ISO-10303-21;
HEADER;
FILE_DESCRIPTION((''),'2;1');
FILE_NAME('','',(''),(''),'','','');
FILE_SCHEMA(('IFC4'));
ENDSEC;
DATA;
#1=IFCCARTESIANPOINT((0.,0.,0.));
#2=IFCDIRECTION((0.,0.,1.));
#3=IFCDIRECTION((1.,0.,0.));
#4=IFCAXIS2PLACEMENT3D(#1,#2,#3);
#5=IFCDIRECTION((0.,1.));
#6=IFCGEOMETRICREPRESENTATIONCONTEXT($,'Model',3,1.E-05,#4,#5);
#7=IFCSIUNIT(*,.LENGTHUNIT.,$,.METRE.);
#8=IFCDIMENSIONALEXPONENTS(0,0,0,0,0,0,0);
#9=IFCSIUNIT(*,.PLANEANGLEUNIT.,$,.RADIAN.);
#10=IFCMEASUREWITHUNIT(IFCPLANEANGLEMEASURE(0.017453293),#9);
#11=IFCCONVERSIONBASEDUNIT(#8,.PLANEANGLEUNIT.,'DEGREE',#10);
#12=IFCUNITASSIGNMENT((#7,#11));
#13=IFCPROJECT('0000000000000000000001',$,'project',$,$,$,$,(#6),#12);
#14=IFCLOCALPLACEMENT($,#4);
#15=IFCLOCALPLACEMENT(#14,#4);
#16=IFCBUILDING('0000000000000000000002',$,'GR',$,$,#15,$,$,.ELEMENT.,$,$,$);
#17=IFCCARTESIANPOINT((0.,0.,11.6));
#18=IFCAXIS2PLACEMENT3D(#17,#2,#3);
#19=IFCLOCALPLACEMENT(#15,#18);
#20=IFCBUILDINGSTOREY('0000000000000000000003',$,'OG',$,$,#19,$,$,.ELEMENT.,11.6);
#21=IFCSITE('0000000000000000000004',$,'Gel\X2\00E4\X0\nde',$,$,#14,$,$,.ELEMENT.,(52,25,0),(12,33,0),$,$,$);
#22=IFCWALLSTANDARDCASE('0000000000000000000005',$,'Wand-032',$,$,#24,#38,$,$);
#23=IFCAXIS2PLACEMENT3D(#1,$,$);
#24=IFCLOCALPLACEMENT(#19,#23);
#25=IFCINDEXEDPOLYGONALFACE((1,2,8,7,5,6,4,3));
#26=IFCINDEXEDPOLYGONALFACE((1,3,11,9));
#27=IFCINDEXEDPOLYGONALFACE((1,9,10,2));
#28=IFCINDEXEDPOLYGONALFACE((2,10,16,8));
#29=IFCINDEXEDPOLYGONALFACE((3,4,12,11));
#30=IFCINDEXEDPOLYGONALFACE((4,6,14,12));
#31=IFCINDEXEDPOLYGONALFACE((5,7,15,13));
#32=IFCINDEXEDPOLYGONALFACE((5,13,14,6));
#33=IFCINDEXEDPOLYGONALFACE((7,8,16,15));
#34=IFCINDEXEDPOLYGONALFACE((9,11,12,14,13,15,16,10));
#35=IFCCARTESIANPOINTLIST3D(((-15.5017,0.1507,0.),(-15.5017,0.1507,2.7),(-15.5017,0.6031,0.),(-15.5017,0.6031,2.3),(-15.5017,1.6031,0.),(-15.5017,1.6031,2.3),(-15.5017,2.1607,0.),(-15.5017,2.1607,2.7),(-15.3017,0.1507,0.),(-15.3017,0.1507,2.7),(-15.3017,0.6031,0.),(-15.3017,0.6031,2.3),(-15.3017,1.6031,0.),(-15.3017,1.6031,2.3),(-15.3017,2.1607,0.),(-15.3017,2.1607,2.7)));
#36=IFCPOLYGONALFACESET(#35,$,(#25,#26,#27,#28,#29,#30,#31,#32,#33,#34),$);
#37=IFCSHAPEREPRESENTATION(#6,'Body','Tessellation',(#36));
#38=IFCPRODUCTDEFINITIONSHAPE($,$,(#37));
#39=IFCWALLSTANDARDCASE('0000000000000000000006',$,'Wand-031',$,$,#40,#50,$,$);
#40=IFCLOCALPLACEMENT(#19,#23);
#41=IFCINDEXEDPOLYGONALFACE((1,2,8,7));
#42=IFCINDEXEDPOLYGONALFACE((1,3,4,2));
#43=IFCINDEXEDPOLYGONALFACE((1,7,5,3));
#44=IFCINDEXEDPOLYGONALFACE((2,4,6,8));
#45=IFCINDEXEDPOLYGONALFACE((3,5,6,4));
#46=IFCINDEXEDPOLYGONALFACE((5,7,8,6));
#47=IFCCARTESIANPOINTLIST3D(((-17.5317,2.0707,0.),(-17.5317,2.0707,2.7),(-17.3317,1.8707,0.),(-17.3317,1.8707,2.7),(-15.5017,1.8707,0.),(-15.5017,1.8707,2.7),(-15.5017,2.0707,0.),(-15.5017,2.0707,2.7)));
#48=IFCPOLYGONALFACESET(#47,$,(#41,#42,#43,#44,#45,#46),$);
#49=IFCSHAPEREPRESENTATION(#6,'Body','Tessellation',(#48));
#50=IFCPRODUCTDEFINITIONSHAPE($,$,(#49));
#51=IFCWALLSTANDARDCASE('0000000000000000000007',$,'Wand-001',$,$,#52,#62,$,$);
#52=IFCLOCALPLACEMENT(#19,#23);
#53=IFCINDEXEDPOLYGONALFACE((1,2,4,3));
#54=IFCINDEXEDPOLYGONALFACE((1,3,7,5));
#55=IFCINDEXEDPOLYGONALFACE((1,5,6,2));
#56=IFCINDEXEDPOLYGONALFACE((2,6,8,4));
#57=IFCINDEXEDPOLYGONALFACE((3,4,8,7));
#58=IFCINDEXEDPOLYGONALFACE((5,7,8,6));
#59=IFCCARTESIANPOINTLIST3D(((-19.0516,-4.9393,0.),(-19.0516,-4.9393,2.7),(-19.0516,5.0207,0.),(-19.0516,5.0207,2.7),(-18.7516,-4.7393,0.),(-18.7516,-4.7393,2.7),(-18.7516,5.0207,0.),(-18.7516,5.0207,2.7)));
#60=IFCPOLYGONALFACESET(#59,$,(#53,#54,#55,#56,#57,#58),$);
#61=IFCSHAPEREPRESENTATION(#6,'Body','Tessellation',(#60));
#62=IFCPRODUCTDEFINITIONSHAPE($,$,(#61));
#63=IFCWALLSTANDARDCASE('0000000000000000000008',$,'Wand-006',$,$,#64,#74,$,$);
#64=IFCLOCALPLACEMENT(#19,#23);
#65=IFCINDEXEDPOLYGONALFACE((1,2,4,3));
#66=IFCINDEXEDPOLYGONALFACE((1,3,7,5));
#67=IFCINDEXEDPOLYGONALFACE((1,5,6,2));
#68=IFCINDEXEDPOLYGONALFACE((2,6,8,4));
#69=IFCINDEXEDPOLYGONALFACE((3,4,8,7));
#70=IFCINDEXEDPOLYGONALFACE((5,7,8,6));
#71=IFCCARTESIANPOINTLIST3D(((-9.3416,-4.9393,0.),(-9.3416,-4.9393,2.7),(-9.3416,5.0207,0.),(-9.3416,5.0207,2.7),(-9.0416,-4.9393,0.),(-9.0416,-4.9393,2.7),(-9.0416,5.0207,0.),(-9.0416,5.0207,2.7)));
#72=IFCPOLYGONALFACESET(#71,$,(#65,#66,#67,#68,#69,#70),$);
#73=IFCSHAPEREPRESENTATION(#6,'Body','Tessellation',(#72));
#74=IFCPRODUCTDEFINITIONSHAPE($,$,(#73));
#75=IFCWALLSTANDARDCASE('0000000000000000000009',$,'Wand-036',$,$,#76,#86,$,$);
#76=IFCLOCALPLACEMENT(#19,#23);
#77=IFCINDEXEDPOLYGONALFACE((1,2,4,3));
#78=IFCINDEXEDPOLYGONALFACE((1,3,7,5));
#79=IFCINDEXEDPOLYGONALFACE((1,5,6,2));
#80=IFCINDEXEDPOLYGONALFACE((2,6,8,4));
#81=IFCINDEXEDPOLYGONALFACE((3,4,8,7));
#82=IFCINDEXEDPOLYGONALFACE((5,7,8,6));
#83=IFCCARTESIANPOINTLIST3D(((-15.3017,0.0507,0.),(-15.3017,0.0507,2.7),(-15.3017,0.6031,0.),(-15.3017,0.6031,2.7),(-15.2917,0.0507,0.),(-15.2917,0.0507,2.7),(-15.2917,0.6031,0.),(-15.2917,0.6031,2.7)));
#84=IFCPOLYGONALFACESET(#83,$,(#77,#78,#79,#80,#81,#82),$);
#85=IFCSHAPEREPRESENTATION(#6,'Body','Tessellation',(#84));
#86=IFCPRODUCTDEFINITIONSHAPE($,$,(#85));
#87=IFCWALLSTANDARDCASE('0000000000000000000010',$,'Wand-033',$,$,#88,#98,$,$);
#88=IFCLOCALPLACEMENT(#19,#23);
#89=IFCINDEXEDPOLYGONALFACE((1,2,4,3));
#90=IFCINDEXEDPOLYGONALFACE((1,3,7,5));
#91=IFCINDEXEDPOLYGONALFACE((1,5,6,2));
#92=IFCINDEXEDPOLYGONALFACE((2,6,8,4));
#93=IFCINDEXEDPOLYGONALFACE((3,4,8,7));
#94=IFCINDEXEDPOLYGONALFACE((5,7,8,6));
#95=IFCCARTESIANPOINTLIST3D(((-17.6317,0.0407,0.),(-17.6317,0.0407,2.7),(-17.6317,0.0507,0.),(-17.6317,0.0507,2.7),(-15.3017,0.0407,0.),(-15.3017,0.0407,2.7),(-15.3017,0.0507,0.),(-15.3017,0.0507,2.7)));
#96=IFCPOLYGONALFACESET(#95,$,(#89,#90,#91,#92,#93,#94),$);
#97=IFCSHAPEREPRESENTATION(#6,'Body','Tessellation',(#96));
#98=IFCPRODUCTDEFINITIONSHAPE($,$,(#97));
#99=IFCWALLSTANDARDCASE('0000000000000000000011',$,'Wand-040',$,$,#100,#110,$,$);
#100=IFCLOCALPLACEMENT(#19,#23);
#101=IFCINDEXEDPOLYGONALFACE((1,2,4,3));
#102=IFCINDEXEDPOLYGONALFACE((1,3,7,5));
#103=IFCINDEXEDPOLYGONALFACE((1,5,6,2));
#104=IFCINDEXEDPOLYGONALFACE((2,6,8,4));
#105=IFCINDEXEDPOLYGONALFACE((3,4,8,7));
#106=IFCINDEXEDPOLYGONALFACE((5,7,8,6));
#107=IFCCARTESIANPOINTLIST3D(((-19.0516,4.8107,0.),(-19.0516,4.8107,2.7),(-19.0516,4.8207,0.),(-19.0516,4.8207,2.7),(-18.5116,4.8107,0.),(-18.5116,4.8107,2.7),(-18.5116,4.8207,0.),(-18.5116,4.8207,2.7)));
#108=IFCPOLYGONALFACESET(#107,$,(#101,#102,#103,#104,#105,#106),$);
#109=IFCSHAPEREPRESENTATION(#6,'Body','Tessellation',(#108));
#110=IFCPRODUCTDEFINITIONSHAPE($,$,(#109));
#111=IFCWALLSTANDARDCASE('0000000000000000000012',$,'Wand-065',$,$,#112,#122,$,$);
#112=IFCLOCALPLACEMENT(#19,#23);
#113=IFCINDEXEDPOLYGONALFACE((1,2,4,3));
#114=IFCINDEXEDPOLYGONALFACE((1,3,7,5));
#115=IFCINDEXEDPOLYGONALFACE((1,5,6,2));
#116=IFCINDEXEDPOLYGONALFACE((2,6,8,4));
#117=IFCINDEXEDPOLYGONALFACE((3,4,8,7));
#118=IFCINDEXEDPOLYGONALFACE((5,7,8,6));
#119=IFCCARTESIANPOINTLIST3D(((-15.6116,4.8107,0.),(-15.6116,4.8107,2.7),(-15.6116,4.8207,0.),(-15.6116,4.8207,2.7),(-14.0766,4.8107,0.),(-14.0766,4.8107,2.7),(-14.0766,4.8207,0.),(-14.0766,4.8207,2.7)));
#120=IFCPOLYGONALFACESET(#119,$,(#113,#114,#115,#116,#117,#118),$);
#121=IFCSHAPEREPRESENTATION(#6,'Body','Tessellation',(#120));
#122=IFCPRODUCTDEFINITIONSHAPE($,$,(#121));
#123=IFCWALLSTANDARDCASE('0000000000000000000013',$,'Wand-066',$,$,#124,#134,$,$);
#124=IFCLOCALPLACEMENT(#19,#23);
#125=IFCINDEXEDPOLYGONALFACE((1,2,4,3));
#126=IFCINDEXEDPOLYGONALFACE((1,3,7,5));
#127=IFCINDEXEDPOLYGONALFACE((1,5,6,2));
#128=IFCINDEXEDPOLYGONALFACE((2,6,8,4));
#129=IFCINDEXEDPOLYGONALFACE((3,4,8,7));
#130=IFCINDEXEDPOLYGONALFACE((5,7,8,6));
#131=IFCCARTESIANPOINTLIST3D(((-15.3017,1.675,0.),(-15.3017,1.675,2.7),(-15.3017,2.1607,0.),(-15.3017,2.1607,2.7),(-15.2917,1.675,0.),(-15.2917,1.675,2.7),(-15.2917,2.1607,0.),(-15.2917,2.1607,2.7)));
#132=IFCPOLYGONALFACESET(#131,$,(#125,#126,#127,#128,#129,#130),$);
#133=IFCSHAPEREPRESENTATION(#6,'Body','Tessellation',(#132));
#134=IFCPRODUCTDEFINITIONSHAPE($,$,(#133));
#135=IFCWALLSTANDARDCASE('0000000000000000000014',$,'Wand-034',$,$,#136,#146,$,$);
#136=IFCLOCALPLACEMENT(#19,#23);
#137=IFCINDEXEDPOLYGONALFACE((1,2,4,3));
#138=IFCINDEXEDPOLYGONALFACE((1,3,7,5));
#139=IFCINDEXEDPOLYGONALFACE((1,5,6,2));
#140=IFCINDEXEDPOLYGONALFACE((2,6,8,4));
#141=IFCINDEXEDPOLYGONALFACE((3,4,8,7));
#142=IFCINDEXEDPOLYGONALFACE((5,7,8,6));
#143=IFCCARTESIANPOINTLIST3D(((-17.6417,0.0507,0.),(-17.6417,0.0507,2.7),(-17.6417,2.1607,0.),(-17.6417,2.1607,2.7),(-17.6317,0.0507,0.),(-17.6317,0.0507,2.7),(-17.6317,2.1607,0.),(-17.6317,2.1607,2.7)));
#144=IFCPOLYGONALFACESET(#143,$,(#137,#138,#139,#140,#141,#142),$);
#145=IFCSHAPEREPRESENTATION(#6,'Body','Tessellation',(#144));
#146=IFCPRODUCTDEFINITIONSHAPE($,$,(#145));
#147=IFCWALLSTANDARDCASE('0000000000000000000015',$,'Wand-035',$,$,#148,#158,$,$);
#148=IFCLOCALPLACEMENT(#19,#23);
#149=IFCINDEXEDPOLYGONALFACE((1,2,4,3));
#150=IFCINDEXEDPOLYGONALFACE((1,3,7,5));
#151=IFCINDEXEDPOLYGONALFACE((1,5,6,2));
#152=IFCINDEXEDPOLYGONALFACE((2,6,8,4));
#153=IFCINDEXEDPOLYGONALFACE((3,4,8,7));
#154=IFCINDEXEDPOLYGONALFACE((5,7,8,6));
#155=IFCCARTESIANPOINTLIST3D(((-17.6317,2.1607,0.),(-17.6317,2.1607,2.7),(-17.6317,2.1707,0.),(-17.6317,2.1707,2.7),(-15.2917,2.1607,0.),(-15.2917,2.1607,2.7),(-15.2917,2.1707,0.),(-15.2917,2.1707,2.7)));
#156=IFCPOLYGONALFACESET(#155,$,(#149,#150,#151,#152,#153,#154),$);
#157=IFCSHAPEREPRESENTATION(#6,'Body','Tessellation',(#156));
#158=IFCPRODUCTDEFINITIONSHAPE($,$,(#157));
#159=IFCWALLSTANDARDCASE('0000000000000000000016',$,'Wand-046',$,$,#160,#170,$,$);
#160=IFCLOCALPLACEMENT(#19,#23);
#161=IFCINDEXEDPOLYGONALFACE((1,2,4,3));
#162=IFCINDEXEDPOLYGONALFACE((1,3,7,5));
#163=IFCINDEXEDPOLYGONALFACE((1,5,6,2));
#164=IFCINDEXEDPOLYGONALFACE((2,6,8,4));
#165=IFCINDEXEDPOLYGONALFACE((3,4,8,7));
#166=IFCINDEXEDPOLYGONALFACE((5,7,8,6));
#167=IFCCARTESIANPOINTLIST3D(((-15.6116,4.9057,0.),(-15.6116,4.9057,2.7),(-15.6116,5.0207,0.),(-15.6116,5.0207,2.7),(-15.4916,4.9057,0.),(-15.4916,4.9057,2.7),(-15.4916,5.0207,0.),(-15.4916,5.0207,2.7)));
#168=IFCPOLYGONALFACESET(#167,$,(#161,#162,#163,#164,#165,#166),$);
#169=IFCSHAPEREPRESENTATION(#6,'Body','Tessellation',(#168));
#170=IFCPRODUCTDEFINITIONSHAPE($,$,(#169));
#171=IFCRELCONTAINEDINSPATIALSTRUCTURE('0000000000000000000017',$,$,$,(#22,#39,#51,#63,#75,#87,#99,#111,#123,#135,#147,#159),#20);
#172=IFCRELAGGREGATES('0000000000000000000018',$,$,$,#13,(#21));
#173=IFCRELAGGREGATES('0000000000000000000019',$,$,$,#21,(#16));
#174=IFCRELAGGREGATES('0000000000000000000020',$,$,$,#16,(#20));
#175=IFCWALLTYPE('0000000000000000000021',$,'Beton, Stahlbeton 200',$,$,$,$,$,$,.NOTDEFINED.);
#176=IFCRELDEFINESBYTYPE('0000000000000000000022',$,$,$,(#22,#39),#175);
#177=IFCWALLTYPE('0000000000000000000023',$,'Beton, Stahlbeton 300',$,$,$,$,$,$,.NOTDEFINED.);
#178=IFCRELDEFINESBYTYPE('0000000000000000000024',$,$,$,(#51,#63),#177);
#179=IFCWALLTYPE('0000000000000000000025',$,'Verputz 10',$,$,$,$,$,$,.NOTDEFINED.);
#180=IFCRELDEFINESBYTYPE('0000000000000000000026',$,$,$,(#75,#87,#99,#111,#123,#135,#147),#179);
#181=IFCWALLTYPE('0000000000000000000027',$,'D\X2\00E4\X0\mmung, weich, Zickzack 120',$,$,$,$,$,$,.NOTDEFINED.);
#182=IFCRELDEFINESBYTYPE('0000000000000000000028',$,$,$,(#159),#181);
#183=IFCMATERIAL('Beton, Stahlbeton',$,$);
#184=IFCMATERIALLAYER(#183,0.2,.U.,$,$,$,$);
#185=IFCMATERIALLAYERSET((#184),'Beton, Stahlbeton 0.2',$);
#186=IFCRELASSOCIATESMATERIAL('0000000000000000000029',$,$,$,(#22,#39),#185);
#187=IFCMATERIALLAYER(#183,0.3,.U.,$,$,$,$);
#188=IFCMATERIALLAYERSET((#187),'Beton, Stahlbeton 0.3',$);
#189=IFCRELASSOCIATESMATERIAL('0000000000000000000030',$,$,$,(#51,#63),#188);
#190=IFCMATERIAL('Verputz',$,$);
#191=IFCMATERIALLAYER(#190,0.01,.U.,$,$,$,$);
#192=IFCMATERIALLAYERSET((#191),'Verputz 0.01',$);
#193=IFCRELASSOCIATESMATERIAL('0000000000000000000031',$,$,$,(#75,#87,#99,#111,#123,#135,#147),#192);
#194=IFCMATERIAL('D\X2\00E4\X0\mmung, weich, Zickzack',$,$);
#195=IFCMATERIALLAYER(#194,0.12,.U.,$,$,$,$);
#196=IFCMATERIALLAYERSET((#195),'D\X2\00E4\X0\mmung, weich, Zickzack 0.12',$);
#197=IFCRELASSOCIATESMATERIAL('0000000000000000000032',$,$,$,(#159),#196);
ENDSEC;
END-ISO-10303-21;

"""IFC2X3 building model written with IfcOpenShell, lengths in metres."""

from ifc_helpers import new_model, entity, si_unit, converted_unit, direction, frame, origin_with_axes, origin_2d_with_axis, place, context, project, spatial, polyline, rectangle, outline, extrude, material, layer, layer_set, layer_usage, type_object, element, save


model = new_model("IFC2X3")

# Units and contexts
model_context = context("Model", 3, precision=1e-05, world=origin_with_axes(), true_north=direction((0.0, 1.0)))
ifc_project = project(units=[si_unit("LENGTHUNIT", "METRE"), converted_unit("PLANEANGLEUNIT", "DEGREE", entity("IfcPlaneAngleMeasure", 0.017453293), si_unit("PLANEANGLEUNIT", "RADIAN"), dimensions=[0, 0, 0, 0, 0, 0, 0])], contexts=[model_context])

# Site, building, storey
site_placement = place(None, origin_with_axes())
site = spatial("IfcSite", under=ifc_project, at=site_placement, Name="Gelände", CompositionType="ELEMENT", RefLatitude=(52, 25, 0), RefLongitude=(12, 33, 0))
building_placement = place(site_placement, origin_with_axes())
building = spatial("IfcBuilding", under=site, at=building_placement, Name="GR", CompositionType="ELEMENT")
storey_placement = place(building_placement, frame((0.0, 0.0, 11.6), z_axis=(0.0, 0.0, 1.0), x_axis=(1.0, 0.0, 0.0)))
storey = spatial("IfcBuildingStorey", under=building, at=storey_placement, Name="OG", CompositionType="ELEMENT", Elevation=11.6)

# Shared definitions
ifc_material_1 = material(Name="Beton, Stahlbeton")
ifc_layer_1 = layer(ifc_material_1, 0.2, ventilated="UNKNOWN")
ifc_layer_set_1 = layer_set([ifc_layer_1], Name="Beton, Stahlbeton 0.2")

# Shared definitions
ifc_material_2 = material(Name="Dämmung, weich, Zickzack")
wall_type_1 = type_object("IfcWallType", Name="Beton, Stahlbeton 200", PredefinedType="NOTDEFINED")

# Wall, opening
ifc_layer_usage_1 = layer_usage(ifc_layer_set_1, "AXIS2", "NEGATIVE", 0.0)
wall_1_placement = place(storey_placement, frame((-15.3017, 2.1607, 0.0), z_axis=(0.0, 0.0, 1.0), x_axis=(0.0, -1.0, 0.0)))
wall_1 = element("IfcWallStandardCase", 1, at=wall_1_placement, inside=storey, type_object=wall_type_1, material=ifc_layer_usage_1, Name="Wand-032", context=model_context, shape_type="SweptSolid", body=[
    extrude(outline(polyline([(0.0, -0.2), (2.01, -0.2), (2.01, 0.0), (0.0, 0.0), (0.0, -0.2)])), origin_with_axes(), (0.0, 0.0, 1.0), 2.7),
])
opening_1_placement = place(wall_1_placement, frame((1.0576, 0.0, 0.0), z_axis=(0.0, 0.0, 1.0), x_axis=(1.0, 0.0, 0.0)))
element("IfcOpeningElement", 2, at=opening_1_placement, cuts=wall_1, context=model_context, shape_type="SweptSolid", body=[
    extrude(rectangle(XDim=1.0, YDim=2.3, at=origin_2d_with_axis()), frame((0.0, 0.001, 1.15), z_axis=(0.0, -1.0, 0.0), x_axis=(1.0, 0.0, 0.0)), (0.0, 0.0, 1.0), 0.602),
])

# Walls
ifc_layer_usage_2 = layer_usage(ifc_layer_set_1, "AXIS2", "NEGATIVE", 0.0)
wall_2_placement = place(storey_placement, frame((-17.5317, 2.0707, 0.0), z_axis=(0.0, 0.0, 1.0), x_axis=(1.0, 0.0, 0.0)))
element("IfcWallStandardCase", 3, at=wall_2_placement, inside=storey, type_object=wall_type_1, material=ifc_layer_usage_2, Name="Wand-031", context=model_context, shape_type="SweptSolid", body=[
    extrude(outline(polyline([(0.2, -0.2), (2.03, -0.2), (2.03, 0.0), (0.0, 0.0), (0.2, -0.2)])), origin_with_axes(), (0.0, 0.0, 1.0), 2.7),
])
ifc_layer_2 = layer(ifc_material_1, 0.3, ventilated="UNKNOWN")
ifc_layer_set_2 = layer_set([ifc_layer_2], Name="Beton, Stahlbeton 0.3")
ifc_layer_usage_3 = layer_usage(ifc_layer_set_2, "AXIS2", "POSITIVE", 0.0)
wall_type_2 = type_object("IfcWallType", Name="Beton, Stahlbeton 300", PredefinedType="NOTDEFINED")
wall_3_placement = place(storey_placement, frame((-19.0516, 5.0207, 0.0), z_axis=(0.0, 0.0, 1.0), x_axis=(0.0, -1.0, 0.0)))
element("IfcWallStandardCase", 4, at=wall_3_placement, inside=storey, type_object=wall_type_2, material=ifc_layer_usage_3, Name="Wand-001", context=model_context, shape_type="SweptSolid", body=[
    extrude(outline(polyline([(0.0, 0.0), (9.96, 0.0), (9.76, 0.3), (0.0, 0.3), (0.0, 0.0)])), origin_with_axes(), (0.0, 0.0, 1.0), 2.7),
])
ifc_layer_usage_4 = layer_usage(ifc_layer_set_2, "AXIS2", "NEGATIVE", 0.0)
wall_4_placement = place(storey_placement, frame((-9.0416, 5.0207, 0.0), z_axis=(0.0, 0.0, 1.0), x_axis=(0.0, -1.0, 0.0)))
element("IfcWallStandardCase", 5, at=wall_4_placement, inside=storey, type_object=wall_type_2, material=ifc_layer_usage_4, Name="Wand-006", context=model_context, shape_type="SweptSolid", body=[
    extrude(outline(polyline([(0.0, -0.3), (9.96, -0.3), (9.96, 0.0), (0.0, 0.0), (0.0, -0.3)])), origin_with_axes(), (0.0, 0.0, 1.0), 2.7),
])
ifc_material_3 = material(Name="Verputz")
ifc_layer_3 = layer(ifc_material_3, 0.01, ventilated="UNKNOWN")
ifc_layer_set_3 = layer_set([ifc_layer_3], Name="Verputz 0.01")
ifc_layer_usage_5 = layer_usage(ifc_layer_set_3, "AXIS2", "NEGATIVE", 0.0)
wall_type_3 = type_object("IfcWallType", Name="Verputz 10", PredefinedType="NOTDEFINED")
wall_5_placement = place(storey_placement, frame((-15.3017, 0.0507, 0.0), z_axis=(0.0, 0.0, 1.0), x_axis=(0.0, 1.0, 0.0)))
element("IfcWallStandardCase", 6, at=wall_5_placement, inside=storey, type_object=wall_type_3, material=ifc_layer_usage_5, Name="Wand-036", context=model_context, shape_type="SweptSolid", body=[
    extrude(outline(polyline([(0.0, -0.01), (0.5524, -0.01), (0.5524, 0.0), (0.0, 0.0), (0.0, -0.01)])), origin_with_axes(), (0.0, 0.0, 1.0), 2.7),
])
ifc_layer_usage_6 = layer_usage(ifc_layer_set_3, "AXIS2", "POSITIVE", 0.0)
wall_6_placement = place(storey_placement, frame((-15.3017, 0.0507, 0.0), z_axis=(0.0, 0.0, 1.0), x_axis=(-1.0, 0.0, 0.0)))
element("IfcWallStandardCase", 7, at=wall_6_placement, inside=storey, type_object=wall_type_3, material=ifc_layer_usage_6, Name="Wand-033", context=model_context, shape_type="SweptSolid", body=[
    extrude(outline(polyline([(0.0, 0.0), (2.33, 0.0), (2.33, 0.01), (0.0, 0.01), (0.0, 0.0)])), origin_with_axes(), (0.0, 0.0, 1.0), 2.7),
])
ifc_layer_usage_7 = layer_usage(ifc_layer_set_3, "AXIS2", "NEGATIVE", 0.0)
wall_7_placement = place(storey_placement, frame((-19.0516, 4.8207, 0.0), z_axis=(0.0, 0.0, 1.0), x_axis=(1.0, 0.0, 0.0)))
element("IfcWallStandardCase", 8, at=wall_7_placement, inside=storey, type_object=wall_type_3, material=ifc_layer_usage_7, Name="Wand-040", context=model_context, shape_type="SweptSolid", body=[
    extrude(outline(polyline([(0.0, -0.01), (0.54, -0.01), (0.54, 0.0), (0.0, 0.0), (0.0, -0.01)])), origin_with_axes(), (0.0, 0.0, 1.0), 2.7),
])
ifc_layer_usage_8 = layer_usage(ifc_layer_set_3, "AXIS2", "NEGATIVE", 0.0)
wall_8_placement = place(storey_placement, frame((-15.6116, 4.8207, 0.0), z_axis=(0.0, 0.0, 1.0), x_axis=(1.0, 0.0, 0.0)))
element("IfcWallStandardCase", 9, at=wall_8_placement, inside=storey, type_object=wall_type_3, material=ifc_layer_usage_8, Name="Wand-065", context=model_context, shape_type="SweptSolid", body=[
    extrude(outline(polyline([(0.0, -0.01), (1.535, -0.01), (1.535, 0.0), (0.0, 0.0), (0.0, -0.01)])), origin_with_axes(), (0.0, 0.0, 1.0), 2.7),
])
ifc_layer_usage_9 = layer_usage(ifc_layer_set_3, "AXIS2", "POSITIVE", 0.0)
wall_9_placement = place(storey_placement, frame((-15.3017, 2.1607, 0.0), z_axis=(0.0, 0.0, 1.0), x_axis=(0.0, -1.0, 0.0)))
element("IfcWallStandardCase", 10, at=wall_9_placement, inside=storey, type_object=wall_type_3, material=ifc_layer_usage_9, Name="Wand-066", context=model_context, shape_type="SweptSolid", body=[
    extrude(outline(polyline([(0.0, 0.0), (0.4857, 0.0), (0.4857, 0.01), (0.0, 0.01), (0.0, 0.0)])), origin_with_axes(), (0.0, 0.0, 1.0), 2.7),
])
ifc_layer_usage_10 = layer_usage(ifc_layer_set_3, "AXIS2", "POSITIVE", 0.0)
wall_10_placement = place(storey_placement, frame((-17.6317, 0.0507, 0.0), z_axis=(0.0, 0.0, 1.0), x_axis=(0.0, 1.0, 0.0)))
element("IfcWallStandardCase", 11, at=wall_10_placement, inside=storey, type_object=wall_type_3, material=ifc_layer_usage_10, Name="Wand-034", context=model_context, shape_type="SweptSolid", body=[
    extrude(outline(polyline([(0.0, 0.0), (2.11, 0.0), (2.11, 0.01), (0.0, 0.01), (0.0, 0.0)])), origin_with_axes(), (0.0, 0.0, 1.0), 2.7),
])
ifc_layer_usage_11 = layer_usage(ifc_layer_set_3, "AXIS2", "NEGATIVE", 0.0)
wall_11_placement = place(storey_placement, frame((-15.2917, 2.1607, 0.0), z_axis=(0.0, 0.0, 1.0), x_axis=(-1.0, 0.0, 0.0)))
element("IfcWallStandardCase", 12, at=wall_11_placement, inside=storey, type_object=wall_type_3, material=ifc_layer_usage_11, Name="Wand-035", context=model_context, shape_type="SweptSolid", body=[
    extrude(outline(polyline([(0.0, -0.01), (2.34, -0.01), (2.34, 0.0), (0.0, 0.0), (0.0, -0.01)])), origin_with_axes(), (0.0, 0.0, 1.0), 2.7),
])
ifc_layer_4 = layer(ifc_material_2, 0.12, ventilated="UNKNOWN")
ifc_layer_set_4 = layer_set([ifc_layer_4], Name="Dämmung, weich, Zickzack 0.12")
ifc_layer_usage_12 = layer_usage(ifc_layer_set_4, "AXIS2", "POSITIVE", 0.0)
wall_type_4 = type_object("IfcWallType", Name="Dämmung, weich, Zickzack 120", PredefinedType="NOTDEFINED")
wall_12_placement = place(storey_placement, frame((-15.6116, 5.0207, 0.0), z_axis=(0.0, 0.0, 1.0), x_axis=(0.0, -1.0, 0.0)))
element("IfcWallStandardCase", 13, at=wall_12_placement, inside=storey, type_object=wall_type_4, material=ifc_layer_usage_12, Name="Wand-046", context=model_context, shape_type="SweptSolid", body=[
    extrude(outline(polyline([(0.0, 0.0), (0.115, 0.0), (0.115, 0.12), (0.0, 0.12), (0.0, 0.0)])), origin_with_axes(), (0.0, 0.0, 1.0), 2.7),
])

save(model, "model.ifc")
